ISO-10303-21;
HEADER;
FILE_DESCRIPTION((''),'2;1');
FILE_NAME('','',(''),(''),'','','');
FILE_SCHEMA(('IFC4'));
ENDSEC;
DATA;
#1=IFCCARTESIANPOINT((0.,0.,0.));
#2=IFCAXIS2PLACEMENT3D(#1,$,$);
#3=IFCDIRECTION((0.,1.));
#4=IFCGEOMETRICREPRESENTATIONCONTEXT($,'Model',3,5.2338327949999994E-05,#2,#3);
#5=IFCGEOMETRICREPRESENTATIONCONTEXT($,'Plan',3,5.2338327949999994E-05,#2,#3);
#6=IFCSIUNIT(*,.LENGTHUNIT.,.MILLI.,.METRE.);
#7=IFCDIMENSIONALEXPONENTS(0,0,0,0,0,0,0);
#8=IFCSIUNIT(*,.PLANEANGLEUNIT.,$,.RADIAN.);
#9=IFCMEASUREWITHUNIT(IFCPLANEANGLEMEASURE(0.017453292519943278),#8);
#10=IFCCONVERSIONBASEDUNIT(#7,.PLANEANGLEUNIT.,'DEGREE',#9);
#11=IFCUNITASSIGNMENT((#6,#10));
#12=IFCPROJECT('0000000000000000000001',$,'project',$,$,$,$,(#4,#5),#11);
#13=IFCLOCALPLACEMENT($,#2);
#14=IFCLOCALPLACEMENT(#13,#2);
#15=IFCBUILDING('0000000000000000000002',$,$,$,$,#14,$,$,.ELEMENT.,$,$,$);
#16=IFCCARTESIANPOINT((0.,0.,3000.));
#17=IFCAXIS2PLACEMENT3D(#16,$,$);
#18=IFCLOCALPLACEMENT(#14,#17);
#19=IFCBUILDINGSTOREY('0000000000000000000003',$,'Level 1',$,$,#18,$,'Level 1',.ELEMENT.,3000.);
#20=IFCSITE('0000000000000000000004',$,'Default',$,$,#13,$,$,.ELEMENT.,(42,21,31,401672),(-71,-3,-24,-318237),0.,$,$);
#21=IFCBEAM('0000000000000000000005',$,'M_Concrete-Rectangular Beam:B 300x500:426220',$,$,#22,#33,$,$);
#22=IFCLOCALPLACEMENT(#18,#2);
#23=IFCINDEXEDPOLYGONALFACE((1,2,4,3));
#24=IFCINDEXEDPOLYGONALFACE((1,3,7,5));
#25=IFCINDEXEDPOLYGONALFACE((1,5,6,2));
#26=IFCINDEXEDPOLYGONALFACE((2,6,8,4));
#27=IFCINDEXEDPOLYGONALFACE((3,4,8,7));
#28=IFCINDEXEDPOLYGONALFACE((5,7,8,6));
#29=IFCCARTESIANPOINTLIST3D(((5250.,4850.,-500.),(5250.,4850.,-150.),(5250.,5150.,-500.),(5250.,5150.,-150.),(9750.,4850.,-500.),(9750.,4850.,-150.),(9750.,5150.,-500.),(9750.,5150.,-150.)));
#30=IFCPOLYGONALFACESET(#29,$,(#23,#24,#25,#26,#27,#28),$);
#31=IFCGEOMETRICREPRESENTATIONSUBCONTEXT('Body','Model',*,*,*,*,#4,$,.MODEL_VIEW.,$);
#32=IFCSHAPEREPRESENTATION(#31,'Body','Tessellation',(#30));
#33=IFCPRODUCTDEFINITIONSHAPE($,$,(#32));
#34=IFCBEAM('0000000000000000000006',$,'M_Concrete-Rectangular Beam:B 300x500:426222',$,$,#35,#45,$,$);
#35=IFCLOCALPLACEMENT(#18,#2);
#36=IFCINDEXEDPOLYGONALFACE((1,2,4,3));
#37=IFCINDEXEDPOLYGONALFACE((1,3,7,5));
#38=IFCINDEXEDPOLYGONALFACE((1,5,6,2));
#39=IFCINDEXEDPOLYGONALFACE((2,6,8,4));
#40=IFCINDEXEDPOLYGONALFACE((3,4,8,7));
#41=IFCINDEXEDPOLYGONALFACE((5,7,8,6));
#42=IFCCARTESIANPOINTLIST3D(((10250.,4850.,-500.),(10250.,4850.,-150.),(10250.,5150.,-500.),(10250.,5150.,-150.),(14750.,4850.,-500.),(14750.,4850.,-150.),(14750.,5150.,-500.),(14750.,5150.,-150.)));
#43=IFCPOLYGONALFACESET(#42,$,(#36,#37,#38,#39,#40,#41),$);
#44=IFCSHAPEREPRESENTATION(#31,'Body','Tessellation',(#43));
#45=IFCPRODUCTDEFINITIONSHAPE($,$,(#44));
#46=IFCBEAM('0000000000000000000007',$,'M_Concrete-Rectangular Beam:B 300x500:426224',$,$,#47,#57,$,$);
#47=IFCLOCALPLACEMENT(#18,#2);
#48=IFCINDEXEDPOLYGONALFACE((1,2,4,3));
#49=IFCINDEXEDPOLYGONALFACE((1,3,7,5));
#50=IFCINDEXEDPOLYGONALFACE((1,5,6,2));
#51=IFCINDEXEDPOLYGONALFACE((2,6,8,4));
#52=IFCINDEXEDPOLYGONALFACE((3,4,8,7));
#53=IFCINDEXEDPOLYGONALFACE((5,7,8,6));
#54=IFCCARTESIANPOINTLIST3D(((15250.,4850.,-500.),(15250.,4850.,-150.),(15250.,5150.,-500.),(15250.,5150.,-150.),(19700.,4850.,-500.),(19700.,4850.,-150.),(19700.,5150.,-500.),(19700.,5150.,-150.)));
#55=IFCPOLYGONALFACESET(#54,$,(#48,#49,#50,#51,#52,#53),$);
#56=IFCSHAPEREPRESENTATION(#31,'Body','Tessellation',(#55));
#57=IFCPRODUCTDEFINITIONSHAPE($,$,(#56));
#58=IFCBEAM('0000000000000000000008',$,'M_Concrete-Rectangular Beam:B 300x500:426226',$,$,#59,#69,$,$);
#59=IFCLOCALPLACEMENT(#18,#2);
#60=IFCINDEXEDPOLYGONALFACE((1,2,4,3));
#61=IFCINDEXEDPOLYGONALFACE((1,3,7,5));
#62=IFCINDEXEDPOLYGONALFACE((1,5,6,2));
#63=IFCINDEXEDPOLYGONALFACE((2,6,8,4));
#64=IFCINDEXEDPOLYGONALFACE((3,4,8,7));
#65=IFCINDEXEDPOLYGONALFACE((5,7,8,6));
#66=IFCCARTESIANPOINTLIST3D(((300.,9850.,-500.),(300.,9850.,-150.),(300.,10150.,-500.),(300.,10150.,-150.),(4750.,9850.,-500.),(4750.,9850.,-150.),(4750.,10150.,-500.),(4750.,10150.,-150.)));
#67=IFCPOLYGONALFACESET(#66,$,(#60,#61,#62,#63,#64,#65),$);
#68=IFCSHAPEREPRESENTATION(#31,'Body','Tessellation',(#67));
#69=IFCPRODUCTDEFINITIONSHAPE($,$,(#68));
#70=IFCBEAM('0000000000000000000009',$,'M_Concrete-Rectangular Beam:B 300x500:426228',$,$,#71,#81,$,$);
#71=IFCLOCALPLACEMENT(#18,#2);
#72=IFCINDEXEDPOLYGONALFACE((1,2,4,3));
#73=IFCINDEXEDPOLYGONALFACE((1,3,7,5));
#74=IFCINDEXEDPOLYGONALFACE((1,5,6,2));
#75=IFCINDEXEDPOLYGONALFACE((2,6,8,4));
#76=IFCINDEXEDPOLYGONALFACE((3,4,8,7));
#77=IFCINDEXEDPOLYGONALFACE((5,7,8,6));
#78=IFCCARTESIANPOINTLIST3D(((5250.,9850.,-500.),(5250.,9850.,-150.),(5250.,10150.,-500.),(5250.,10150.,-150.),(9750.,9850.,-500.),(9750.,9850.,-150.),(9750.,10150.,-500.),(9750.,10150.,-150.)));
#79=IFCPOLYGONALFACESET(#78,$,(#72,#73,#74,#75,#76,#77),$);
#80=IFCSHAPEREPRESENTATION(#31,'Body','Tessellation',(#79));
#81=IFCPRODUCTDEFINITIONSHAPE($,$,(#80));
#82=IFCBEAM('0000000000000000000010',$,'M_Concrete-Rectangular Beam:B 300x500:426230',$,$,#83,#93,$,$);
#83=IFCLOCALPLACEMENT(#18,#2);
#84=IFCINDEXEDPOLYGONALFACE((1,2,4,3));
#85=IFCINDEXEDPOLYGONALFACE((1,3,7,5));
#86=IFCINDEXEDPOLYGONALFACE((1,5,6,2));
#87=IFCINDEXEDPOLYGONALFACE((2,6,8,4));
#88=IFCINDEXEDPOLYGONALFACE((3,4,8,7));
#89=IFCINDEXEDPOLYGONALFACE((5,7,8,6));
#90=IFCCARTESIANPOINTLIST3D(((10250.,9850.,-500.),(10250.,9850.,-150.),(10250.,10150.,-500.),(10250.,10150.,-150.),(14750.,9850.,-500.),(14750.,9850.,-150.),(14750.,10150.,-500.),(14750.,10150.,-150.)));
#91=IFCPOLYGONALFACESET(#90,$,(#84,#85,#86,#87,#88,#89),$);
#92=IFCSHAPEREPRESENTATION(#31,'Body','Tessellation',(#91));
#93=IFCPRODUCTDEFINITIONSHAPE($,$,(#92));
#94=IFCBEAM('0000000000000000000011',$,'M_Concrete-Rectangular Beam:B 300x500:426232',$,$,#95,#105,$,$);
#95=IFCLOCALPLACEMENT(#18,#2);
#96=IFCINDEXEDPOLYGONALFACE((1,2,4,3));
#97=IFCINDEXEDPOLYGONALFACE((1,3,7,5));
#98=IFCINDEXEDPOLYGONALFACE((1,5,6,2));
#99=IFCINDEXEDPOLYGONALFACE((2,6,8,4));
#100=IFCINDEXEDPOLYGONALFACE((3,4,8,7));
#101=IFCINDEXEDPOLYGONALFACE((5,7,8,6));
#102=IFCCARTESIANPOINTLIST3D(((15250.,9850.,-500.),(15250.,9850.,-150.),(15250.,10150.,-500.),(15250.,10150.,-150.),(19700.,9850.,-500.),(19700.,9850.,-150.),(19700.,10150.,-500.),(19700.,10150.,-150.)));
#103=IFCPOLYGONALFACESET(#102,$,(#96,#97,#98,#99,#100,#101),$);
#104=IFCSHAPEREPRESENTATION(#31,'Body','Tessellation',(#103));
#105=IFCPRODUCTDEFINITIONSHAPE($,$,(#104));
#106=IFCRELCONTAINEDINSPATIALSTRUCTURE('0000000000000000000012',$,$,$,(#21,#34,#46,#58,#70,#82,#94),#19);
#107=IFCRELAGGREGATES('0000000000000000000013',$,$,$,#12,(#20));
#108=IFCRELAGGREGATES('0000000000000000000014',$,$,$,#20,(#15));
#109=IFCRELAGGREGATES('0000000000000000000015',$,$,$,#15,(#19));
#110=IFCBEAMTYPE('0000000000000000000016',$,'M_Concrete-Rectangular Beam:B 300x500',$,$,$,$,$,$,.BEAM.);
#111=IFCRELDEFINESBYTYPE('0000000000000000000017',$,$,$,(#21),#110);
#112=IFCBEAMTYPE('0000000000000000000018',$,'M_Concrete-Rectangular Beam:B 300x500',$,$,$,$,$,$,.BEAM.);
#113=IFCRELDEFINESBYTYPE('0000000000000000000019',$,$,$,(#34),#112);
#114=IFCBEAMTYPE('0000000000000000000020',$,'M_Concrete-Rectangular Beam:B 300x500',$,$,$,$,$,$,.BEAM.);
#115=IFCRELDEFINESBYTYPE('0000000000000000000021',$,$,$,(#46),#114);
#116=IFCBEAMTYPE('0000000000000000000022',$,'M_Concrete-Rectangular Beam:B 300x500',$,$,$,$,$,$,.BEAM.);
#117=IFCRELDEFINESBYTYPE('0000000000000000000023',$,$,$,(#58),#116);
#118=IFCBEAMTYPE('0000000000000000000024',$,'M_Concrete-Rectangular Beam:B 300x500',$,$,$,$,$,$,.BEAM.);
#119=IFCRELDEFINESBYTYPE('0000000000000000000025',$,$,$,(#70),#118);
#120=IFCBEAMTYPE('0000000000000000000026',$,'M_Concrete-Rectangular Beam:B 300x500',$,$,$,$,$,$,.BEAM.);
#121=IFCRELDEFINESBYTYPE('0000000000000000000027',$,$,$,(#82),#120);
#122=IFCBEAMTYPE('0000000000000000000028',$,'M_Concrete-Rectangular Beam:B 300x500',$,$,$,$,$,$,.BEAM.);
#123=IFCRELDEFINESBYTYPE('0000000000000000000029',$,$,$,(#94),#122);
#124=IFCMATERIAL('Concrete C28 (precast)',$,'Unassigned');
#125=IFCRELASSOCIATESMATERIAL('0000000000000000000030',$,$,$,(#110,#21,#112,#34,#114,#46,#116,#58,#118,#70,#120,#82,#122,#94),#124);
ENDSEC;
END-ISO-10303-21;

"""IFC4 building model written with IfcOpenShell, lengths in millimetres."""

from ifc_helpers import new_model, entity, si_unit, converted_unit, direction, frame, origin, place, context, subcontext, project, spatial, indexed_curve, outline, extrude, source, transform, mapped, material, type_object, type_shapes, element, save


model = new_model("IFC4")

# Units and contexts
model_context = context("Model", 3, precision=5.2338327949999994e-05, world=origin(), true_north=direction((0.0, 1.0)))
plan_context = context("Plan", 3, precision=5.2338327949999994e-05, world=origin(), true_north=direction((0.0, 1.0)))
body_context = subcontext(model_context, "Body", "Model", "MODEL_VIEW")
ifc_project = project(units=[si_unit("LENGTHUNIT", "METRE", prefix="MILLI"), converted_unit("PLANEANGLEUNIT", "DEGREE", entity("IfcPlaneAngleMeasure", 0.017453292519943278), si_unit("PLANEANGLEUNIT", "RADIAN"), dimensions=[0, 0, 0, 0, 0, 0, 0])], contexts=[model_context, plan_context])

# Site, building, storey
site_placement = place(None, origin())
site = spatial("IfcSite", under=ifc_project, at=site_placement, Name="Default", CompositionType="ELEMENT", RefLatitude=(42, 21, 31, 401672), RefLongitude=(-71, -3, -24, -318237), RefElevation=0.0)
building_placement = place(site_placement, origin())
building = spatial("IfcBuilding", under=site, at=building_placement, CompositionType="ELEMENT")
storey_placement = place(building_placement, frame((0.0, 0.0, 3000.0)))
storey = spatial("IfcBuildingStorey", under=building, at=storey_placement, Name="Level 1", LongName="Level 1", CompositionType="ELEMENT", Elevation=3000.0)

# Shared definitions
ifc_material = material(Name="Concrete C28 (precast)", Category="Unassigned")

# Beams
beam_type_1 = type_object("IfcBeamType", Name="M_Concrete-Rectangular Beam:B 300x500", PredefinedType="BEAM", material=ifc_material)
shared_shape_1 = source(origin(), body_context, "Body", "SweptSolid", [
    extrude(outline(indexed_curve([(-175.0, -150.0), (175.0, -150.0), (175.0, 150.0), (-175.0, 150.0), (-175.0, -150.0)], self_intersect=False)), frame((5250.0, 5000.0, 2675.0), z_axis=(1.0, 0.0, 0.0), x_axis=(0.0, 0.0, -1.0)), (0.0, 0.0, 1.0), 4500.0),
])
type_shapes(beam_type_1, [shared_shape_1])
beam_1_placement = place(storey_placement, frame((0.0, 0.0, -3000.0)))
element("IfcBeam", 1, at=beam_1_placement, inside=storey, type_object=beam_type_1, material=ifc_material, Name="M_Concrete-Rectangular Beam:B 300x500:426220", context=body_context, shape_type="MappedRepresentation", body=[
    mapped(shared_shape_1, transform((0.0, 0.0, 0.0), scale=1.0)),
])
beam_type_2 = type_object("IfcBeamType", Name="M_Concrete-Rectangular Beam:B 300x500", PredefinedType="BEAM", material=ifc_material)
shared_shape_2 = source(origin(), body_context, "Body", "SweptSolid", [
    extrude(outline(indexed_curve([(-175.0, -150.0), (175.0, -150.0), (175.0, 150.0), (-175.0, 150.0), (-175.0, -150.0)], self_intersect=False)), frame((10250.0, 5000.0, 2675.0), z_axis=(1.0, 0.0, 0.0), x_axis=(0.0, 0.0, -1.0)), (0.0, 0.0, 1.0), 4500.0),
])
type_shapes(beam_type_2, [shared_shape_2])
beam_2_placement = place(storey_placement, frame((0.0, 0.0, -3000.0)))
element("IfcBeam", 2, at=beam_2_placement, inside=storey, type_object=beam_type_2, material=ifc_material, Name="M_Concrete-Rectangular Beam:B 300x500:426222", context=body_context, shape_type="MappedRepresentation", body=[
    mapped(shared_shape_2, transform((0.0, 0.0, 0.0), scale=1.0)),
])
beam_type_3 = type_object("IfcBeamType", Name="M_Concrete-Rectangular Beam:B 300x500", PredefinedType="BEAM", material=ifc_material)
shared_shape_3 = source(origin(), body_context, "Body", "SweptSolid", [
    extrude(outline(indexed_curve([(-175.0, -150.0), (175.0, -150.0), (175.0, 150.0), (-175.0, 150.0), (-175.0, -150.0)], self_intersect=False)), frame((15250.0, 5000.0, 2675.0), z_axis=(1.0, 0.0, 0.0), x_axis=(0.0, 0.0, -1.0)), (0.0, 0.0, 1.0), 4450.0),
])
type_shapes(beam_type_3, [shared_shape_3])
beam_3_placement = place(storey_placement, frame((0.0, 0.0, -3000.0)))
element("IfcBeam", 3, at=beam_3_placement, inside=storey, type_object=beam_type_3, material=ifc_material, Name="M_Concrete-Rectangular Beam:B 300x500:426224", context=body_context, shape_type="MappedRepresentation", body=[
    mapped(shared_shape_3, transform((0.0, 0.0, 0.0), scale=1.0)),
])
beam_type_4 = type_object("IfcBeamType", Name="M_Concrete-Rectangular Beam:B 300x500", PredefinedType="BEAM", material=ifc_material)
shared_shape_4 = source(origin(), body_context, "Body", "SweptSolid", [
    extrude(outline(indexed_curve([(-175.0, -150.0), (175.0, -150.0), (175.0, 150.0), (-175.0, 150.0), (-175.0, -150.0)], self_intersect=False)), frame((300.0, 10000.0, 2675.0), z_axis=(1.0, 0.0, 0.0), x_axis=(0.0, 0.0, -1.0)), (0.0, 0.0, 1.0), 4450.0),
])
type_shapes(beam_type_4, [shared_shape_4])
beam_4_placement = place(storey_placement, frame((0.0, 0.0, -3000.0)))
element("IfcBeam", 4, at=beam_4_placement, inside=storey, type_object=beam_type_4, material=ifc_material, Name="M_Concrete-Rectangular Beam:B 300x500:426226", context=body_context, shape_type="MappedRepresentation", body=[
    mapped(shared_shape_4, transform((0.0, 0.0, 0.0), scale=1.0)),
])
beam_type_5 = type_object("IfcBeamType", Name="M_Concrete-Rectangular Beam:B 300x500", PredefinedType="BEAM", material=ifc_material)
shared_shape_5 = source(origin(), body_context, "Body", "SweptSolid", [
    extrude(outline(indexed_curve([(-175.0, -150.0), (175.0, -150.0), (175.0, 150.0), (-175.0, 150.0), (-175.0, -150.0)], self_intersect=False)), frame((5250.0, 10000.0, 2675.0), z_axis=(1.0, 0.0, 0.0), x_axis=(0.0, 0.0, -1.0)), (0.0, 0.0, 1.0), 4500.0),
])
type_shapes(beam_type_5, [shared_shape_5])
beam_5_placement = place(storey_placement, frame((0.0, 0.0, -3000.0)))
element("IfcBeam", 5, at=beam_5_placement, inside=storey, type_object=beam_type_5, material=ifc_material, Name="M_Concrete-Rectangular Beam:B 300x500:426228", context=body_context, shape_type="MappedRepresentation", body=[
    mapped(shared_shape_5, transform((0.0, 0.0, 0.0), scale=1.0)),
])
beam_type_6 = type_object("IfcBeamType", Name="M_Concrete-Rectangular Beam:B 300x500", PredefinedType="BEAM", material=ifc_material)
shared_shape_6 = source(origin(), body_context, "Body", "SweptSolid", [
    extrude(outline(indexed_curve([(-175.0, -150.0), (175.0, -150.0), (175.0, 150.0), (-175.0, 150.0), (-175.0, -150.0)], self_intersect=False)), frame((10250.0, 10000.0, 2675.0), z_axis=(1.0, 0.0, 0.0), x_axis=(0.0, 0.0, -1.0)), (0.0, 0.0, 1.0), 4500.0),
])
type_shapes(beam_type_6, [shared_shape_6])
beam_6_placement = place(storey_placement, frame((0.0, 0.0, -3000.0)))
element("IfcBeam", 6, at=beam_6_placement, inside=storey, type_object=beam_type_6, material=ifc_material, Name="M_Concrete-Rectangular Beam:B 300x500:426230", context=body_context, shape_type="MappedRepresentation", body=[
    mapped(shared_shape_6, transform((0.0, 0.0, 0.0), scale=1.0)),
])
beam_type_7 = type_object("IfcBeamType", Name="M_Concrete-Rectangular Beam:B 300x500", PredefinedType="BEAM", material=ifc_material)
shared_shape_7 = source(origin(), body_context, "Body", "SweptSolid", [
    extrude(outline(indexed_curve([(-175.0, -150.0), (175.0, -150.0), (175.0, 150.0), (-175.0, 150.0), (-175.0, -150.0)], self_intersect=False)), frame((15250.0, 10000.0, 2675.0), z_axis=(1.0, 0.0, 0.0), x_axis=(0.0, 0.0, -1.0)), (0.0, 0.0, 1.0), 4450.0),
])
type_shapes(beam_type_7, [shared_shape_7])
beam_7_placement = place(storey_placement, frame((0.0, 0.0, -3000.0)))
element("IfcBeam", 7, at=beam_7_placement, inside=storey, type_object=beam_type_7, material=ifc_material, Name="M_Concrete-Rectangular Beam:B 300x500:426232", context=body_context, shape_type="MappedRepresentation", body=[
    mapped(shared_shape_7, transform((0.0, 0.0, 0.0), scale=1.0)),
])

save(model, "model.ifc")
